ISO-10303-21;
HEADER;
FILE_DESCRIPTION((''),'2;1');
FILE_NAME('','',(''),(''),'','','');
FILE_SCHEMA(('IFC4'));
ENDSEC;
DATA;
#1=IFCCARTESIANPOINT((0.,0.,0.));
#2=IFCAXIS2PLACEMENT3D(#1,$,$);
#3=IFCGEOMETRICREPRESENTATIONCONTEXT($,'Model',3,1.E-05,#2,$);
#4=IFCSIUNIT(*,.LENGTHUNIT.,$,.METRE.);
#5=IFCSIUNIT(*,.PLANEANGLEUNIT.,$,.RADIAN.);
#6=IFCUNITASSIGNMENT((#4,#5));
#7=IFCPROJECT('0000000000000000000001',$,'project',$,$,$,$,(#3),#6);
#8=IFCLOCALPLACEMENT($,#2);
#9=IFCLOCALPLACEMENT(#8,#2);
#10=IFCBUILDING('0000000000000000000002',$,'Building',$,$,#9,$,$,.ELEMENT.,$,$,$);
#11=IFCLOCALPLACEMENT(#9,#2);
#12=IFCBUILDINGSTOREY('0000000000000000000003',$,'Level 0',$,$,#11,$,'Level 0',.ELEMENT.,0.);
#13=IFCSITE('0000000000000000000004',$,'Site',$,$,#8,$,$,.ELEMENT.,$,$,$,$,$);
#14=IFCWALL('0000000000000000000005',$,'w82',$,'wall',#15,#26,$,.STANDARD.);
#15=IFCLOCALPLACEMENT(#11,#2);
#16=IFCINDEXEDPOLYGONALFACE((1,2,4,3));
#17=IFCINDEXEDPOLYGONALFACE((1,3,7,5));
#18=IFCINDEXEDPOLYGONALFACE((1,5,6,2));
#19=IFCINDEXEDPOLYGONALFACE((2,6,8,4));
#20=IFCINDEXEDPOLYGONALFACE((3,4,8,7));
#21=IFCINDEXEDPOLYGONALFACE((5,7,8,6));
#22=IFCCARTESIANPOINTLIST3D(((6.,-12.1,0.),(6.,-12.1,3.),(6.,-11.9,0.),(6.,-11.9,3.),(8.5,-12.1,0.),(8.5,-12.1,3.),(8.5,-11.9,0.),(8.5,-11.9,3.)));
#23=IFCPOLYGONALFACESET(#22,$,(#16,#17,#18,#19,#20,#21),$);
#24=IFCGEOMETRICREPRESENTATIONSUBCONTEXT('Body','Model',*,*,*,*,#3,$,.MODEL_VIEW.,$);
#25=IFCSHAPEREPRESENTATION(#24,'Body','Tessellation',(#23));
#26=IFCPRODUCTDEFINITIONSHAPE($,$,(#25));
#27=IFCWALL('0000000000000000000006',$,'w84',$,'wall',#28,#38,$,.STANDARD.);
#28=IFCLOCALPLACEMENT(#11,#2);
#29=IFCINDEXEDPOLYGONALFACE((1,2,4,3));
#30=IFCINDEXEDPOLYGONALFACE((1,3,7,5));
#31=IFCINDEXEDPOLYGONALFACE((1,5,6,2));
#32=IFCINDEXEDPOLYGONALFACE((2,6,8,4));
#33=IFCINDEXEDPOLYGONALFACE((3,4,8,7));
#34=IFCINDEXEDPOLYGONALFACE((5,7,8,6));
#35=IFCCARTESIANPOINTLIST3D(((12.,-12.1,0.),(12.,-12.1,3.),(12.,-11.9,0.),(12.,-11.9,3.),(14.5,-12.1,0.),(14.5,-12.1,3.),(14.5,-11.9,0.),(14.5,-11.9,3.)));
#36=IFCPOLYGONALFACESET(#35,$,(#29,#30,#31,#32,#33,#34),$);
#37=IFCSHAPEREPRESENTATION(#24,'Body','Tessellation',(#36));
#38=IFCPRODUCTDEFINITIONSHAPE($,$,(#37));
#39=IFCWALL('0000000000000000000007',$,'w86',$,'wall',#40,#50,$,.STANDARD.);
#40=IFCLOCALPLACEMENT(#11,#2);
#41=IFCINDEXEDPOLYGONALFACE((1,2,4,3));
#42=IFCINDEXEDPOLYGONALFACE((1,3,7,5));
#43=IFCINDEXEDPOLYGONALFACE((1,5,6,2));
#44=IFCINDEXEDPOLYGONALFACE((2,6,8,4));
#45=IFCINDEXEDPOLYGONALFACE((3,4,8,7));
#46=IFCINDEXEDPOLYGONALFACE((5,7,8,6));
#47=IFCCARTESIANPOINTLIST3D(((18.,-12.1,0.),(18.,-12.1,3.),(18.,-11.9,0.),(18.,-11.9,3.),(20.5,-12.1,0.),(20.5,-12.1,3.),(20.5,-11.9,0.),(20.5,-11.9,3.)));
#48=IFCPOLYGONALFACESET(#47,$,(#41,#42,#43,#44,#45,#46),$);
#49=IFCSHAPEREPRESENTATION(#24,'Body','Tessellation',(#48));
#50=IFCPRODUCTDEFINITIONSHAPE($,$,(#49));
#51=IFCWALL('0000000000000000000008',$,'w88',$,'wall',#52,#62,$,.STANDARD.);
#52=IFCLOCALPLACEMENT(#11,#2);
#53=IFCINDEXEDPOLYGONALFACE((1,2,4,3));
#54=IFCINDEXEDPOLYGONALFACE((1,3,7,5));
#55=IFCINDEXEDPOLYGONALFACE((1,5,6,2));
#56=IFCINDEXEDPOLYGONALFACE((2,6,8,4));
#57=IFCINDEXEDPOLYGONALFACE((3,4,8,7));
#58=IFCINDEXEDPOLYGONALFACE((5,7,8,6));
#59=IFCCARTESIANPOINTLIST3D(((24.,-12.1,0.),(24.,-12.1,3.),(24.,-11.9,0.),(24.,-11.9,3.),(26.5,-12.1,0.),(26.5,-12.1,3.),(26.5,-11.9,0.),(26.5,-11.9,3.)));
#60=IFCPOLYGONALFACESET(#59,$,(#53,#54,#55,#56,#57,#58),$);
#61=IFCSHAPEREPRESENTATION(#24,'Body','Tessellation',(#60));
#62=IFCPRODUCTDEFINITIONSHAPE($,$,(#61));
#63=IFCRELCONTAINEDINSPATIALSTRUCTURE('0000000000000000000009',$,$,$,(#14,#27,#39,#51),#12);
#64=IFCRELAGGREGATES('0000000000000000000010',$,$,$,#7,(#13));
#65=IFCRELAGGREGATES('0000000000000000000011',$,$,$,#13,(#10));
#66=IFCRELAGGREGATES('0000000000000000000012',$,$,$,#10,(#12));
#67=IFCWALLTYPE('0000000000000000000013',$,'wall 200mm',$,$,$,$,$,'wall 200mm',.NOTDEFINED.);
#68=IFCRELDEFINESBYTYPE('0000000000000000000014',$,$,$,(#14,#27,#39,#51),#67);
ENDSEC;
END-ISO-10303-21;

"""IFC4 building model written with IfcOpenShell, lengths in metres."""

from ifc_helpers import new_model, si_unit, frame, frame_2d, origin, place, context, subcontext, project, spatial, rectangle, extrude, type_object, element, save


model = new_model("IFC4")

# Units and contexts
model_context = context("Model", 3, precision=1e-05, world=origin())
body_context = subcontext(model_context, "Body", "Model", "MODEL_VIEW")
ifc_project = project(units=[si_unit("LENGTHUNIT", "METRE"), si_unit("PLANEANGLEUNIT", "RADIAN")], contexts=[model_context])

# Site, building, storey
site_placement = place(None, origin())
site = spatial("IfcSite", under=ifc_project, at=site_placement, Name="Site", CompositionType="ELEMENT")
building_placement = place(site_placement, origin())
building = spatial("IfcBuilding", under=site, at=building_placement, Name="Building", CompositionType="ELEMENT")
storey_placement = place(building_placement, origin())
storey = spatial("IfcBuildingStorey", under=building, at=storey_placement, Name="Level 0", LongName="Level 0", CompositionType="ELEMENT", Elevation=0.0)

# Walls
wall_type = type_object("IfcWallType", Name="wall 200mm", ElementType="wall 200mm", PredefinedType="NOTDEFINED")
for number, where, z_axis, x_axis, name in (
    (1, (6.0, -12.0, 0.0), (0.0, 0.0, 1.0), (1.0, 0.0, 0.0), "w82"),
    (2, (12.0, -12.0, 0.0), (0.0, 0.0, 1.0), (1.0, 0.0, 0.0), "w84"),
    (3, (18.0, -12.0, 0.0), (0.0, 0.0, 1.0), (1.0, 0.0, 0.0), "w86"),
    (4, (24.0, -12.0, 0.0), (0.0, 0.0, 1.0), (1.0, 0.0, 0.0), "w88"),
):
    element("IfcWall", number, at=place(storey_placement, frame(where, z_axis=z_axis, x_axis=x_axis)), inside=storey, type_object=wall_type, Name=name, ObjectType="wall", PredefinedType="STANDARD", context=body_context, shape_type="SweptSolid", body=[
        extrude(rectangle(XDim=2.5, YDim=0.2, at=frame_2d((1.25, 0.0))), origin(), (0.0, 0.0, 1.0), 3.0),
    ])

save(model, "model.ifc")
